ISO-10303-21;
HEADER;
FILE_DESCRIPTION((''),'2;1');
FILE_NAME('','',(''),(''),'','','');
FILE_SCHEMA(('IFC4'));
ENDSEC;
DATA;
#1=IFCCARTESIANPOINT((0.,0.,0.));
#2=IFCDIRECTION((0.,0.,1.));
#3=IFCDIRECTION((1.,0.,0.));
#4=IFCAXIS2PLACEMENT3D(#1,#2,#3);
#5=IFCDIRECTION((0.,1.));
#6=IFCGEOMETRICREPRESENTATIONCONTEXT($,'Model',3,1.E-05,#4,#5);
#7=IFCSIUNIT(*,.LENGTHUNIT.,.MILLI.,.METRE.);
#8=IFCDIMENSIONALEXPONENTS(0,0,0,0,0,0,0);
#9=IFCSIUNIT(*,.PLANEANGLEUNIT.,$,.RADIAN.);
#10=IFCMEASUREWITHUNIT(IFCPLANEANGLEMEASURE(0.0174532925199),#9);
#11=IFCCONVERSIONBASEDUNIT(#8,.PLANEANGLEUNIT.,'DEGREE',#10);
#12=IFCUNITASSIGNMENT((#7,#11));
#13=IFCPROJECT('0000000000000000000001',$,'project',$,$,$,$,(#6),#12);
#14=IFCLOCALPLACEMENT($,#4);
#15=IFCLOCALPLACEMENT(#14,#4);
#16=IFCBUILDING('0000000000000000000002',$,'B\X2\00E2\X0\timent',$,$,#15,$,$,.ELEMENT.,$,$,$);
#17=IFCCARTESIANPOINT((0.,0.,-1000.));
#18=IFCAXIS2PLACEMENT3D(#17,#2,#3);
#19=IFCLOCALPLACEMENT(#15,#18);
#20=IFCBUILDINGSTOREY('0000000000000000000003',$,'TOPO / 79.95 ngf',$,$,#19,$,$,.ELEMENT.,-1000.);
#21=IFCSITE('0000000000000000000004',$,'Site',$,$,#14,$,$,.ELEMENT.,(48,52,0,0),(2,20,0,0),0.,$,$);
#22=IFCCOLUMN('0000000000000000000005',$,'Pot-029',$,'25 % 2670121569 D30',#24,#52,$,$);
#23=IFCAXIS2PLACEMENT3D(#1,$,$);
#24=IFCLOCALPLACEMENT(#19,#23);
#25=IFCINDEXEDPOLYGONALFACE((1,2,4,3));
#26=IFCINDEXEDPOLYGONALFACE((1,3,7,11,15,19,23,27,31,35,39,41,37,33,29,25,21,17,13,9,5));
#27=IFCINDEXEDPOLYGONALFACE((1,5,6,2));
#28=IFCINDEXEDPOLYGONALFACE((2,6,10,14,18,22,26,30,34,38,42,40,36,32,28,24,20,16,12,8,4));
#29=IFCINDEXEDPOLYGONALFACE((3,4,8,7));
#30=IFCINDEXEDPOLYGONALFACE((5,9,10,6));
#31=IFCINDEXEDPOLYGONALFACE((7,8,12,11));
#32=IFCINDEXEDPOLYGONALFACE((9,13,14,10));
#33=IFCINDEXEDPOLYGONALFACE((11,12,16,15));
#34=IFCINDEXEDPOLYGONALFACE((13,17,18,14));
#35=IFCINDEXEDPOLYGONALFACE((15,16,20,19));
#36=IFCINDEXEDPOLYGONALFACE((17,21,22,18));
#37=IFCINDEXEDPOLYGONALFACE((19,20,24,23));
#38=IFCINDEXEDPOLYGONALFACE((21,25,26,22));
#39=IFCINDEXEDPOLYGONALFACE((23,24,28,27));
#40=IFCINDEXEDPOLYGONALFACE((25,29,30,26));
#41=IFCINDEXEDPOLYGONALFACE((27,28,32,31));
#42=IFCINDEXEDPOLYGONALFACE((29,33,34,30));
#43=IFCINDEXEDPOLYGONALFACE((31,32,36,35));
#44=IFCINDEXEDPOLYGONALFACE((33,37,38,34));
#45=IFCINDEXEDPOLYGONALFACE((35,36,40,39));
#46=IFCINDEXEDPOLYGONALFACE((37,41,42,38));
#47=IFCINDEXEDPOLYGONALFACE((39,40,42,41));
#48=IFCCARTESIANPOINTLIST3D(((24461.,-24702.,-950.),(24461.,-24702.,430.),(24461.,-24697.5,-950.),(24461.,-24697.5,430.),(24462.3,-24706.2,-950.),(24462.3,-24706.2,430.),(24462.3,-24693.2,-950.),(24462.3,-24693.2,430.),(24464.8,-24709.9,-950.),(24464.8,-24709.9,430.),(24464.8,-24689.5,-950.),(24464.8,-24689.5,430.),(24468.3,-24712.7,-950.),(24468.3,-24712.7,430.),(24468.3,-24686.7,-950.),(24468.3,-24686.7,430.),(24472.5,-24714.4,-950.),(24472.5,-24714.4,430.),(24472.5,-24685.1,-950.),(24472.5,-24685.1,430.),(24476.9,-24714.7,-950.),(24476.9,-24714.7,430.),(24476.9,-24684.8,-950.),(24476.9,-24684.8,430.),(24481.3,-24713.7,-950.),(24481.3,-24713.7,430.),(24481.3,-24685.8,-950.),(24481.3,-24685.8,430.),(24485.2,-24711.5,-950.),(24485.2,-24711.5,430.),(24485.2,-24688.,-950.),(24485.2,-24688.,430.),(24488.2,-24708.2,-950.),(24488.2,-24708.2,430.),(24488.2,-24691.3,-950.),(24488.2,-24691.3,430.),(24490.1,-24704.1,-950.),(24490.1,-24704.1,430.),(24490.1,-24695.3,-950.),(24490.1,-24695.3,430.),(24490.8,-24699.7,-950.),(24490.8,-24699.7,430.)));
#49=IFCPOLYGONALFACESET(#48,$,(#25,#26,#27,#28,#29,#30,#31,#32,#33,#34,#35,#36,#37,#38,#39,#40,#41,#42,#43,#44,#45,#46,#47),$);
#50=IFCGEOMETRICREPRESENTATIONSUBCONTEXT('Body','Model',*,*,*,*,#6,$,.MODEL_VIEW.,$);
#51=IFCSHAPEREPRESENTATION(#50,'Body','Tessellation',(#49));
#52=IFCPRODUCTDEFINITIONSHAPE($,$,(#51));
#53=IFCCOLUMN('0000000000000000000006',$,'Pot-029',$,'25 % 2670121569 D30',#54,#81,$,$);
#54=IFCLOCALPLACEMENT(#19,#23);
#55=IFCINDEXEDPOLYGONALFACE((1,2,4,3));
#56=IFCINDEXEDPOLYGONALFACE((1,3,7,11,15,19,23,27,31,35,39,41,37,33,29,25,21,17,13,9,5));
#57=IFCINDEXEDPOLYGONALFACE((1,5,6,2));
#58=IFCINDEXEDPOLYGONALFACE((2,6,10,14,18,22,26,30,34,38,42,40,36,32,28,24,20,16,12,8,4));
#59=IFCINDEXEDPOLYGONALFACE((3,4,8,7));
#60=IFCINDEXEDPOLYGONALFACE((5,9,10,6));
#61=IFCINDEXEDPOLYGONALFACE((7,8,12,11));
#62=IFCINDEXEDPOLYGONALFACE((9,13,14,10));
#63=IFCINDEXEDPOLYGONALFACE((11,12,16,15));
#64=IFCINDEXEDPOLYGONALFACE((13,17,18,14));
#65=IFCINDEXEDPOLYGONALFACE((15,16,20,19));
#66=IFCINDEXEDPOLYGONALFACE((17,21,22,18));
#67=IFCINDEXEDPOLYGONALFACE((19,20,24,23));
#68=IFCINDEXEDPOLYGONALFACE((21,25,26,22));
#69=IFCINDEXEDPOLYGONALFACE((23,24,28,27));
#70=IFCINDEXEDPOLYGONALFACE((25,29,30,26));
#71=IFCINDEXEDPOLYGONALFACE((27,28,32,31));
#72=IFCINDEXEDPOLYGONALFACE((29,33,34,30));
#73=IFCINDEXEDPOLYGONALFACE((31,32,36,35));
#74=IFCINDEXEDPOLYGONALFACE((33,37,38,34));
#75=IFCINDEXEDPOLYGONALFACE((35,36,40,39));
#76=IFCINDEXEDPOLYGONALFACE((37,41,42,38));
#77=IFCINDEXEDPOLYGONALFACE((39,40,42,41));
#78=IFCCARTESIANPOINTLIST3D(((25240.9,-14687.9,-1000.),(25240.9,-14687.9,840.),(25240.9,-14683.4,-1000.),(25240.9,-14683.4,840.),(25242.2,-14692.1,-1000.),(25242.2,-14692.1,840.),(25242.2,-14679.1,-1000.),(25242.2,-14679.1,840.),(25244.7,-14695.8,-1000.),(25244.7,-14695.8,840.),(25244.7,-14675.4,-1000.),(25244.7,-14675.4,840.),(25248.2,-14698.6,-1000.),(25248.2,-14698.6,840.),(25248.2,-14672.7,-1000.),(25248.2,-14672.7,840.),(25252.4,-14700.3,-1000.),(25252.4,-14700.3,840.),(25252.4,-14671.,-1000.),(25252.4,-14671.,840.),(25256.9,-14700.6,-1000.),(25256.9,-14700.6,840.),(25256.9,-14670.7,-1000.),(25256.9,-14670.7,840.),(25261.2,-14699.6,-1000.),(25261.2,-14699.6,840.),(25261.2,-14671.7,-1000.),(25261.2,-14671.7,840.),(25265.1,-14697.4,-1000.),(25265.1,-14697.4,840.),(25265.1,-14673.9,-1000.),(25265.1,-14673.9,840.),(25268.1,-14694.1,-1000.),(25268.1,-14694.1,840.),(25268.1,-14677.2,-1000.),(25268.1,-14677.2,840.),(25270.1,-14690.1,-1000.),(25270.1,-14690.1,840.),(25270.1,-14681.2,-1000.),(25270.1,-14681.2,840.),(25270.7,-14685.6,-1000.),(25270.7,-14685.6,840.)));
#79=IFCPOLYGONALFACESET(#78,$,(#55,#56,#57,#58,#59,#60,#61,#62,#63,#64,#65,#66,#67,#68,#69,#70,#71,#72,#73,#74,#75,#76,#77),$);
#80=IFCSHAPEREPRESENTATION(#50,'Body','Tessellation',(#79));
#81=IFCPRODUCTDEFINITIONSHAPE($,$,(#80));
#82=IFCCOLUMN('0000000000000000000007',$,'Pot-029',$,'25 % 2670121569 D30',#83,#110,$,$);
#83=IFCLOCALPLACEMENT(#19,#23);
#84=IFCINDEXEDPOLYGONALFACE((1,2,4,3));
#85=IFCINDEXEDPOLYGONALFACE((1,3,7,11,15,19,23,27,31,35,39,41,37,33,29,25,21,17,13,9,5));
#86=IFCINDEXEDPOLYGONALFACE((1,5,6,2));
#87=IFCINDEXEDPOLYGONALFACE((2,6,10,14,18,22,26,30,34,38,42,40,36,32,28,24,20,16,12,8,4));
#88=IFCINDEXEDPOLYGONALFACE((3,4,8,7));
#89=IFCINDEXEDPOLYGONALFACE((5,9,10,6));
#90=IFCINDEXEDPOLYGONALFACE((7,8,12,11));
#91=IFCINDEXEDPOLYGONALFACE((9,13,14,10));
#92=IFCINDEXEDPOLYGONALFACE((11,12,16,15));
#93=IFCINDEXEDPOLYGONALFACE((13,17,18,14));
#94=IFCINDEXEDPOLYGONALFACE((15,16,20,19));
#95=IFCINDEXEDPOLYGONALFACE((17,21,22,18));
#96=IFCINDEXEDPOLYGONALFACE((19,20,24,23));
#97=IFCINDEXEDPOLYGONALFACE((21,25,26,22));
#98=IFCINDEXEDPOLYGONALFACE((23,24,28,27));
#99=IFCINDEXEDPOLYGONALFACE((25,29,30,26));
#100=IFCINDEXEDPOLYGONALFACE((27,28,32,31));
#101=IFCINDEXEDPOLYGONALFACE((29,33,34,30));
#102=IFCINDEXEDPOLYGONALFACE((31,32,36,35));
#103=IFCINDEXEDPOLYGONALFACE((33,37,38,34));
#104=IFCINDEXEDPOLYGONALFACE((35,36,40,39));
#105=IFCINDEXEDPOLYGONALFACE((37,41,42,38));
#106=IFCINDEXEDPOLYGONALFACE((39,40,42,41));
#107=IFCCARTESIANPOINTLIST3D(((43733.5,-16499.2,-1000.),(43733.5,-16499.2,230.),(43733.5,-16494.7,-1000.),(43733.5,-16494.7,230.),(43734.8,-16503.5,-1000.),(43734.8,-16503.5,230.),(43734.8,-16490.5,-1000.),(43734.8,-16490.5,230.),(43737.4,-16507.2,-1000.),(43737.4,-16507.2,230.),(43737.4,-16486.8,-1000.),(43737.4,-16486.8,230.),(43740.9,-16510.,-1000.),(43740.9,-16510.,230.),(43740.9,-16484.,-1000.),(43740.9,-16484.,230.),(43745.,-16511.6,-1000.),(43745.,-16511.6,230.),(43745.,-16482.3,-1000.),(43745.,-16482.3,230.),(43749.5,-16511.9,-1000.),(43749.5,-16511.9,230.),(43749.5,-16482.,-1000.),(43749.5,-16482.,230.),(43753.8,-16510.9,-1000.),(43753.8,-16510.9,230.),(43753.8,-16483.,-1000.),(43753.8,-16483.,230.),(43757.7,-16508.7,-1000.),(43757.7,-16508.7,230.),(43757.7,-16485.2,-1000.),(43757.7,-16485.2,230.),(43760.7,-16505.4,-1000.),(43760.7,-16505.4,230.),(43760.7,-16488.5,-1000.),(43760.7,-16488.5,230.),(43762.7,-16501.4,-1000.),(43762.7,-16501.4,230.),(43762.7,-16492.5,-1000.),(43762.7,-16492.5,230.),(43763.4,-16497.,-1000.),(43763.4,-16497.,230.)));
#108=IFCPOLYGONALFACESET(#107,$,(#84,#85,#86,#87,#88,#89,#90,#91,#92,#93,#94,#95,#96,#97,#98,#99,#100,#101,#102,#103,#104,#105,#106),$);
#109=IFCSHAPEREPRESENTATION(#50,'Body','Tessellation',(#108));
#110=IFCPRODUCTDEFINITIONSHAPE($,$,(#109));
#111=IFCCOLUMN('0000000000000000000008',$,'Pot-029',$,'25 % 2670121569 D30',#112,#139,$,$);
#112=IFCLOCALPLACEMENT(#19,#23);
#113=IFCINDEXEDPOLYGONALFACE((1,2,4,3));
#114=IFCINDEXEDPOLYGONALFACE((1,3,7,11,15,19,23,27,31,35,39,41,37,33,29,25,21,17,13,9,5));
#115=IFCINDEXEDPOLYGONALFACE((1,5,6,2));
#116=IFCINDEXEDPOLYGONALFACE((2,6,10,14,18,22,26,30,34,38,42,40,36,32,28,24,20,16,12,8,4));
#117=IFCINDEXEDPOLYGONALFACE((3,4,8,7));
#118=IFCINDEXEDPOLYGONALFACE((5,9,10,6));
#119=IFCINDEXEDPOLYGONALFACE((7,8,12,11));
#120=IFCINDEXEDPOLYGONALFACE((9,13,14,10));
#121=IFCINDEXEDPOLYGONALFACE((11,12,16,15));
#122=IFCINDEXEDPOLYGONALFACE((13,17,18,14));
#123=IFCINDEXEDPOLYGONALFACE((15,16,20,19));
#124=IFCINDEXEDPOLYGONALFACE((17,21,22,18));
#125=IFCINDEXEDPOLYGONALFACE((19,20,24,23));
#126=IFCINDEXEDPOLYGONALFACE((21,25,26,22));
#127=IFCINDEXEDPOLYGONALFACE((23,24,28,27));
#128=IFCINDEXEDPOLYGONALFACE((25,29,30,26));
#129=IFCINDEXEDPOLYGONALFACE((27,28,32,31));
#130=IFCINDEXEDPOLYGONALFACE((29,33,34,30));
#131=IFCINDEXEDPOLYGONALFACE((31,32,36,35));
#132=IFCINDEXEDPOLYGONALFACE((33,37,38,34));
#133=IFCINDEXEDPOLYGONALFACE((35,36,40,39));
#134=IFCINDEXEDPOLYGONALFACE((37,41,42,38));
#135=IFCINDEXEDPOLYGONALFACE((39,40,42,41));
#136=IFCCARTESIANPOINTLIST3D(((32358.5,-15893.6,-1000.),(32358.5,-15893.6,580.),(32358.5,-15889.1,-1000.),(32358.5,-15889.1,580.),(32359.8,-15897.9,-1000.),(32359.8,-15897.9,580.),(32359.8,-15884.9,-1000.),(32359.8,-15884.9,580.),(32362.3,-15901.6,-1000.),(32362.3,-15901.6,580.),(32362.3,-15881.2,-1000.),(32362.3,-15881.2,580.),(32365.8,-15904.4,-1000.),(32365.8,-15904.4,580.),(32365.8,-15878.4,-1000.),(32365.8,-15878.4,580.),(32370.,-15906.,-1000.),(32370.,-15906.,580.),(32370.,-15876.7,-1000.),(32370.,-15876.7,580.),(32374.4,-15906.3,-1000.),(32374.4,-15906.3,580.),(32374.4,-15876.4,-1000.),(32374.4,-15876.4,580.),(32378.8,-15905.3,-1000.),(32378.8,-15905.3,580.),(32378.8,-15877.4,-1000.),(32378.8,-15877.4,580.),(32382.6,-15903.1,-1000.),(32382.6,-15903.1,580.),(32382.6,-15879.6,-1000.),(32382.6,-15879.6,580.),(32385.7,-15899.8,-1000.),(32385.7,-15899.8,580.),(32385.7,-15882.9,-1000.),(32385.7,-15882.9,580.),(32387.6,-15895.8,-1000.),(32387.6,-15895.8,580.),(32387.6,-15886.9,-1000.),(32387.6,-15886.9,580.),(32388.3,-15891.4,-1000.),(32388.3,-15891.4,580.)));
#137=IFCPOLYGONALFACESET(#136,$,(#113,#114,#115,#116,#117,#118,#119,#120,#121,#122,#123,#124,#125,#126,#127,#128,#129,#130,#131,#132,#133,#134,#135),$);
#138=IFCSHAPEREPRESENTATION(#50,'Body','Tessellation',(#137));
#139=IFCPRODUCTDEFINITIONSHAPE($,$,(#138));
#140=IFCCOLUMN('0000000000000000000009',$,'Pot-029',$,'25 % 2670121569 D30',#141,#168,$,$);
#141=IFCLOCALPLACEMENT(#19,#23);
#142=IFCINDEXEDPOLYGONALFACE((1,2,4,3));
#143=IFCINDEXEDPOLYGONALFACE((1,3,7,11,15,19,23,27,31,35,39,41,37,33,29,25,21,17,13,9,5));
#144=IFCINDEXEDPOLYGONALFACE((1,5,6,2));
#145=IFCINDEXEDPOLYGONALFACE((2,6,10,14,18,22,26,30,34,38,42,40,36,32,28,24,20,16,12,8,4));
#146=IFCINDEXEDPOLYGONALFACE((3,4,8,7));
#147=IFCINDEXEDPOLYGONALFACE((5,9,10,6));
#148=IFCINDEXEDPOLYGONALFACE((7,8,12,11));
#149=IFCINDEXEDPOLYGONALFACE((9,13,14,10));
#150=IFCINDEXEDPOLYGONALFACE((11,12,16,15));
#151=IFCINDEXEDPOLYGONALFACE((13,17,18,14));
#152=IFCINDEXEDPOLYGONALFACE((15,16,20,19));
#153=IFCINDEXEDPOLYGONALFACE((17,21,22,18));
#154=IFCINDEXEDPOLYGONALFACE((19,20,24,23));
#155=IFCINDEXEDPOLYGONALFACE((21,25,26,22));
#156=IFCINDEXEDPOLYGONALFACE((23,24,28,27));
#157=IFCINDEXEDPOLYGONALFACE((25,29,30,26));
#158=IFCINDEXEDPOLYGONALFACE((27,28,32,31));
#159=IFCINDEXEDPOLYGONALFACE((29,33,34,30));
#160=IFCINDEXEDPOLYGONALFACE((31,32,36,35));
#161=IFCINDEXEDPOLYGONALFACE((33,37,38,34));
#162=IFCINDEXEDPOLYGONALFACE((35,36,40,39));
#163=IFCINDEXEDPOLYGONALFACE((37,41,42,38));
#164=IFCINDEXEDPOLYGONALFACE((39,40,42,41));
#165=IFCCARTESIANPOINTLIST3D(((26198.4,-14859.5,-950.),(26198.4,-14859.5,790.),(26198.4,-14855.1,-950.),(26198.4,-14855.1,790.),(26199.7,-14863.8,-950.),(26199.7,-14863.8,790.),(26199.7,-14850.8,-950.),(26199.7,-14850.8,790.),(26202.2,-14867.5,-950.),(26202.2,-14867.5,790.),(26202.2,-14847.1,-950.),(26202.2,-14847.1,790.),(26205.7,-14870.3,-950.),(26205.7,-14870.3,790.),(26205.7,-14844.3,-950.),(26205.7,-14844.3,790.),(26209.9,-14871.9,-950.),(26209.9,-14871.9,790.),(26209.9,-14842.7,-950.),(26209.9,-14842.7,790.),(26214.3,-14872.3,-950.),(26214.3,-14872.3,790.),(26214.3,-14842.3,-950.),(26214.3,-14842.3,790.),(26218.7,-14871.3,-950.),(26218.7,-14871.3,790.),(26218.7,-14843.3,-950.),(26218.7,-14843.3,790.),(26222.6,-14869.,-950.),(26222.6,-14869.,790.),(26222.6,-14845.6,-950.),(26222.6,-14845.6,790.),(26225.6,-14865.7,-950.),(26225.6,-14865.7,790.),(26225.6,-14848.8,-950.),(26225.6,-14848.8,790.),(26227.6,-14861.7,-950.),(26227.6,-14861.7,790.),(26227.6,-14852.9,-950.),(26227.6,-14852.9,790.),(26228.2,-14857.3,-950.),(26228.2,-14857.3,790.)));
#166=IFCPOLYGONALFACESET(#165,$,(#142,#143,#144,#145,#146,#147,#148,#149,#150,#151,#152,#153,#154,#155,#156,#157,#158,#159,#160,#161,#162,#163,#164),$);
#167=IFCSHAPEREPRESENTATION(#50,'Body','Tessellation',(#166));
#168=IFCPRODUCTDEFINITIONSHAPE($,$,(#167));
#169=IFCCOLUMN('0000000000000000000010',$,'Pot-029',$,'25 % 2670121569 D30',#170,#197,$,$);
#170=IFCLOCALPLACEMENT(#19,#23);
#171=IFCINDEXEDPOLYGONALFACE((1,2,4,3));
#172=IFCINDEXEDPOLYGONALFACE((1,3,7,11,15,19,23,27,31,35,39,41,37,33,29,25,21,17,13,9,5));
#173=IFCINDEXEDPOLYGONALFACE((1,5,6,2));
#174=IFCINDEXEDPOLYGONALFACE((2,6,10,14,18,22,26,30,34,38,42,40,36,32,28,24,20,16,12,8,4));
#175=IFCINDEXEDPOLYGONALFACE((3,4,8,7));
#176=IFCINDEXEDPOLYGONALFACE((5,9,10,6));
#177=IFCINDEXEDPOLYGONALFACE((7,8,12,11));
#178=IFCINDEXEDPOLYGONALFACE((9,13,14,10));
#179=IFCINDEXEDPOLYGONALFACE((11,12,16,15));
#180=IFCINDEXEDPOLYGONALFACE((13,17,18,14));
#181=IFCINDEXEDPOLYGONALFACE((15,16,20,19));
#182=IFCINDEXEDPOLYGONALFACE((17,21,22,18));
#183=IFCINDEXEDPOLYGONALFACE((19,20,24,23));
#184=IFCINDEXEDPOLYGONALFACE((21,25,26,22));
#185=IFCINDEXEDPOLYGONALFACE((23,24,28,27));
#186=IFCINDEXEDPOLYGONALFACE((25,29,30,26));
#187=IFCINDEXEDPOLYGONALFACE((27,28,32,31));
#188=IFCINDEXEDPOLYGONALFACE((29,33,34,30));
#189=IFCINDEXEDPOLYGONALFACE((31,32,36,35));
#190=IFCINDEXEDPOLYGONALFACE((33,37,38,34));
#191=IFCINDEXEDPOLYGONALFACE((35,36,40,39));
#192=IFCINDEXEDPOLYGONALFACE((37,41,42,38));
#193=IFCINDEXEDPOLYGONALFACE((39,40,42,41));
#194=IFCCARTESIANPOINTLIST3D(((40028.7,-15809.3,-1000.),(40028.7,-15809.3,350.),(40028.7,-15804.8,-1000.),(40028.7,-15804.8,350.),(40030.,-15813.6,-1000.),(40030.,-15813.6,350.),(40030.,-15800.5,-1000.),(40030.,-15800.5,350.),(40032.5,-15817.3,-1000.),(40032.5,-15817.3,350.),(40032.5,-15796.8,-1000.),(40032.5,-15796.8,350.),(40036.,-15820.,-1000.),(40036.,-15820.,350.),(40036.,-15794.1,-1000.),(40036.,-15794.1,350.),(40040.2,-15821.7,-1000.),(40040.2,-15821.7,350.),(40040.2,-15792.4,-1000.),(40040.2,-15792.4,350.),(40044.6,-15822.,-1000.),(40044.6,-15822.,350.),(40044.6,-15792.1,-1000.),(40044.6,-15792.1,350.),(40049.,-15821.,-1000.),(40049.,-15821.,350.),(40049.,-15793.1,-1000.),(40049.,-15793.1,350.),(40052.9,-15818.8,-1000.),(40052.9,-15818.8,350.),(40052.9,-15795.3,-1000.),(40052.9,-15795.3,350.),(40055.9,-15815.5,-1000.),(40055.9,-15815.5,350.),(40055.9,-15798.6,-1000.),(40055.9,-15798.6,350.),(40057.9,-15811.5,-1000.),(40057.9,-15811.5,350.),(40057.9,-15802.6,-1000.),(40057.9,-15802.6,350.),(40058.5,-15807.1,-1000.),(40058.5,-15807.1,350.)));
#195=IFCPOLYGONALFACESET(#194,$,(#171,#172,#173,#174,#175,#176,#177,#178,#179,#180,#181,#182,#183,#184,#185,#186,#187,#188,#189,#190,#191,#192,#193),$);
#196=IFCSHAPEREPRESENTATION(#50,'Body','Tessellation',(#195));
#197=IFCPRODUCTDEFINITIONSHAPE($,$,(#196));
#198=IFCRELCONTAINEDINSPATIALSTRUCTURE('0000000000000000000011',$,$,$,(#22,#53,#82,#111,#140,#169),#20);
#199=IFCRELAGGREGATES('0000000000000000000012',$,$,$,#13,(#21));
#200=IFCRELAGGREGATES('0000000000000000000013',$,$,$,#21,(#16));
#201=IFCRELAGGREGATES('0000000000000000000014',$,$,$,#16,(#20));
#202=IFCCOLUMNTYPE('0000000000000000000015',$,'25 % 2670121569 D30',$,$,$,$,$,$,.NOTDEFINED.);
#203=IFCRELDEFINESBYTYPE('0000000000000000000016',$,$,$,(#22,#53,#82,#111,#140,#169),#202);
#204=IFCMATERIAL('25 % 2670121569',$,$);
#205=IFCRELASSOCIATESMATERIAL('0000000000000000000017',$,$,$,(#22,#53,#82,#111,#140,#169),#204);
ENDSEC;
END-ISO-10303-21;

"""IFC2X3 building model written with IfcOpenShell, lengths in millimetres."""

from ifc_helpers import new_model, entity, si_unit, converted_unit, direction, frame, origin_with_axes, origin_2d_with_axis, place, context, subcontext, project, spatial, circle, extrude, material, type_object, element, save


model = new_model("IFC2X3")

# Units and contexts
model_context = context("Model", 3, precision=1e-05, world=origin_with_axes(), true_north=direction((0.0, 1.0)))
body_context = subcontext(model_context, "Body", "Model", "MODEL_VIEW")
ifc_project = project(units=[si_unit("LENGTHUNIT", "METRE", prefix="MILLI"), converted_unit("PLANEANGLEUNIT", "DEGREE", entity("IfcPlaneAngleMeasure", 0.0174532925199), si_unit("PLANEANGLEUNIT", "RADIAN"), dimensions=[0, 0, 0, 0, 0, 0, 0])], contexts=[model_context])

# Site, building, storey
site_placement = place(None, origin_with_axes())
site = spatial("IfcSite", under=ifc_project, at=site_placement, Name="Site", CompositionType="ELEMENT", RefLatitude=(48, 52, 0, 0), RefLongitude=(2, 20, 0, 0), RefElevation=0.0)
building_placement = place(site_placement, origin_with_axes())
building = spatial("IfcBuilding", under=site, at=building_placement, Name="Bâtiment", CompositionType="ELEMENT")
storey_placement = place(building_placement, frame((0.0, 0.0, -1000.0), z_axis=(0.0, 0.0, 1.0), x_axis=(1.0, 0.0, 0.0)))
storey = spatial("IfcBuildingStorey", under=building, at=storey_placement, Name="TOPO / 79.95 ngf", CompositionType="ELEMENT", Elevation=-1000.0)

# Columns
ifc_material_1 = material(Name="25 % 2670121569")
column_type_1 = type_object("IfcColumnType", Name="25 % 2670121569 D30", PredefinedType="NOTDEFINED")
column_1_placement = place(storey_placement, frame((24475.8, -24699.7, -950.0), z_axis=(0.0, 0.0, 1.0), x_axis=(1.0, 0.0, 0.0)))
element("IfcColumn", 1, at=column_1_placement, inside=storey, type_object=column_type_1, material=ifc_material_1, Name="Pot-029", ObjectType="25 % 2670121569 D30", context=body_context, shape_type="SweptSolid", body=[
    extrude(circle(Radius=15.0, at=origin_2d_with_axis()), origin_with_axes(), (0.0, 0.0, 1.0), 1380.0),
])
column_2_placement = place(storey_placement, frame((25255.7, -14685.6, -1000.0), z_axis=(0.0, 0.0, 1.0), x_axis=(1.0, 0.0, 0.0)))
element("IfcColumn", 2, at=column_2_placement, inside=storey, type_object=column_type_1, material=ifc_material_1, Name="Pot-029", ObjectType="25 % 2670121569 D30", context=body_context, shape_type="SweptSolid", body=[
    extrude(circle(Radius=15.0, at=origin_2d_with_axis()), origin_with_axes(), (0.0, 0.0, 1.0), 1840.0),
])
column_3_placement = place(storey_placement, frame((43748.4, -16497.0, -1000.0), z_axis=(0.0, 0.0, 1.0), x_axis=(1.0, 0.0, 0.0)))
element("IfcColumn", 3, at=column_3_placement, inside=storey, type_object=column_type_1, material=ifc_material_1, Name="Pot-029", ObjectType="25 % 2670121569 D30", context=body_context, shape_type="SweptSolid", body=[
    extrude(circle(Radius=15.0, at=origin_2d_with_axis()), origin_with_axes(), (0.0, 0.0, 1.0), 1230.0),
])
column_4_placement = place(storey_placement, frame((32373.3, -15891.4, -1000.0), z_axis=(0.0, 0.0, 1.0), x_axis=(1.0, 0.0, 0.0)))
element("IfcColumn", 4, at=column_4_placement, inside=storey, type_object=column_type_1, material=ifc_material_1, Name="Pot-029", ObjectType="25 % 2670121569 D30", context=body_context, shape_type="SweptSolid", body=[
    extrude(circle(Radius=15.0, at=origin_2d_with_axis()), origin_with_axes(), (0.0, 0.0, 1.0), 1580.0),
])
column_5_placement = place(storey_placement, frame((26213.2, -14857.3, -950.0), z_axis=(0.0, 0.0, 1.0), x_axis=(1.0, 0.0, 0.0)))
element("IfcColumn", 5, at=column_5_placement, inside=storey, type_object=column_type_1, material=ifc_material_1, Name="Pot-029", ObjectType="25 % 2670121569 D30", context=body_context, shape_type="SweptSolid", body=[
    extrude(circle(Radius=15.0, at=origin_2d_with_axis()), origin_with_axes(), (0.0, 0.0, 1.0), 1740.0),
])
column_6_placement = place(storey_placement, frame((40043.5, -15807.1, -1000.0), z_axis=(0.0, 0.0, 1.0), x_axis=(1.0, 0.0, 0.0)))
element("IfcColumn", 6, at=column_6_placement, inside=storey, type_object=column_type_1, material=ifc_material_1, Name="Pot-029", ObjectType="25 % 2670121569 D30", context=body_context, shape_type="SweptSolid", body=[
    extrude(circle(Radius=15.0, at=origin_2d_with_axis()), origin_with_axes(), (0.0, 0.0, 1.0), 1350.0),
])

save(model, "model.ifc")
